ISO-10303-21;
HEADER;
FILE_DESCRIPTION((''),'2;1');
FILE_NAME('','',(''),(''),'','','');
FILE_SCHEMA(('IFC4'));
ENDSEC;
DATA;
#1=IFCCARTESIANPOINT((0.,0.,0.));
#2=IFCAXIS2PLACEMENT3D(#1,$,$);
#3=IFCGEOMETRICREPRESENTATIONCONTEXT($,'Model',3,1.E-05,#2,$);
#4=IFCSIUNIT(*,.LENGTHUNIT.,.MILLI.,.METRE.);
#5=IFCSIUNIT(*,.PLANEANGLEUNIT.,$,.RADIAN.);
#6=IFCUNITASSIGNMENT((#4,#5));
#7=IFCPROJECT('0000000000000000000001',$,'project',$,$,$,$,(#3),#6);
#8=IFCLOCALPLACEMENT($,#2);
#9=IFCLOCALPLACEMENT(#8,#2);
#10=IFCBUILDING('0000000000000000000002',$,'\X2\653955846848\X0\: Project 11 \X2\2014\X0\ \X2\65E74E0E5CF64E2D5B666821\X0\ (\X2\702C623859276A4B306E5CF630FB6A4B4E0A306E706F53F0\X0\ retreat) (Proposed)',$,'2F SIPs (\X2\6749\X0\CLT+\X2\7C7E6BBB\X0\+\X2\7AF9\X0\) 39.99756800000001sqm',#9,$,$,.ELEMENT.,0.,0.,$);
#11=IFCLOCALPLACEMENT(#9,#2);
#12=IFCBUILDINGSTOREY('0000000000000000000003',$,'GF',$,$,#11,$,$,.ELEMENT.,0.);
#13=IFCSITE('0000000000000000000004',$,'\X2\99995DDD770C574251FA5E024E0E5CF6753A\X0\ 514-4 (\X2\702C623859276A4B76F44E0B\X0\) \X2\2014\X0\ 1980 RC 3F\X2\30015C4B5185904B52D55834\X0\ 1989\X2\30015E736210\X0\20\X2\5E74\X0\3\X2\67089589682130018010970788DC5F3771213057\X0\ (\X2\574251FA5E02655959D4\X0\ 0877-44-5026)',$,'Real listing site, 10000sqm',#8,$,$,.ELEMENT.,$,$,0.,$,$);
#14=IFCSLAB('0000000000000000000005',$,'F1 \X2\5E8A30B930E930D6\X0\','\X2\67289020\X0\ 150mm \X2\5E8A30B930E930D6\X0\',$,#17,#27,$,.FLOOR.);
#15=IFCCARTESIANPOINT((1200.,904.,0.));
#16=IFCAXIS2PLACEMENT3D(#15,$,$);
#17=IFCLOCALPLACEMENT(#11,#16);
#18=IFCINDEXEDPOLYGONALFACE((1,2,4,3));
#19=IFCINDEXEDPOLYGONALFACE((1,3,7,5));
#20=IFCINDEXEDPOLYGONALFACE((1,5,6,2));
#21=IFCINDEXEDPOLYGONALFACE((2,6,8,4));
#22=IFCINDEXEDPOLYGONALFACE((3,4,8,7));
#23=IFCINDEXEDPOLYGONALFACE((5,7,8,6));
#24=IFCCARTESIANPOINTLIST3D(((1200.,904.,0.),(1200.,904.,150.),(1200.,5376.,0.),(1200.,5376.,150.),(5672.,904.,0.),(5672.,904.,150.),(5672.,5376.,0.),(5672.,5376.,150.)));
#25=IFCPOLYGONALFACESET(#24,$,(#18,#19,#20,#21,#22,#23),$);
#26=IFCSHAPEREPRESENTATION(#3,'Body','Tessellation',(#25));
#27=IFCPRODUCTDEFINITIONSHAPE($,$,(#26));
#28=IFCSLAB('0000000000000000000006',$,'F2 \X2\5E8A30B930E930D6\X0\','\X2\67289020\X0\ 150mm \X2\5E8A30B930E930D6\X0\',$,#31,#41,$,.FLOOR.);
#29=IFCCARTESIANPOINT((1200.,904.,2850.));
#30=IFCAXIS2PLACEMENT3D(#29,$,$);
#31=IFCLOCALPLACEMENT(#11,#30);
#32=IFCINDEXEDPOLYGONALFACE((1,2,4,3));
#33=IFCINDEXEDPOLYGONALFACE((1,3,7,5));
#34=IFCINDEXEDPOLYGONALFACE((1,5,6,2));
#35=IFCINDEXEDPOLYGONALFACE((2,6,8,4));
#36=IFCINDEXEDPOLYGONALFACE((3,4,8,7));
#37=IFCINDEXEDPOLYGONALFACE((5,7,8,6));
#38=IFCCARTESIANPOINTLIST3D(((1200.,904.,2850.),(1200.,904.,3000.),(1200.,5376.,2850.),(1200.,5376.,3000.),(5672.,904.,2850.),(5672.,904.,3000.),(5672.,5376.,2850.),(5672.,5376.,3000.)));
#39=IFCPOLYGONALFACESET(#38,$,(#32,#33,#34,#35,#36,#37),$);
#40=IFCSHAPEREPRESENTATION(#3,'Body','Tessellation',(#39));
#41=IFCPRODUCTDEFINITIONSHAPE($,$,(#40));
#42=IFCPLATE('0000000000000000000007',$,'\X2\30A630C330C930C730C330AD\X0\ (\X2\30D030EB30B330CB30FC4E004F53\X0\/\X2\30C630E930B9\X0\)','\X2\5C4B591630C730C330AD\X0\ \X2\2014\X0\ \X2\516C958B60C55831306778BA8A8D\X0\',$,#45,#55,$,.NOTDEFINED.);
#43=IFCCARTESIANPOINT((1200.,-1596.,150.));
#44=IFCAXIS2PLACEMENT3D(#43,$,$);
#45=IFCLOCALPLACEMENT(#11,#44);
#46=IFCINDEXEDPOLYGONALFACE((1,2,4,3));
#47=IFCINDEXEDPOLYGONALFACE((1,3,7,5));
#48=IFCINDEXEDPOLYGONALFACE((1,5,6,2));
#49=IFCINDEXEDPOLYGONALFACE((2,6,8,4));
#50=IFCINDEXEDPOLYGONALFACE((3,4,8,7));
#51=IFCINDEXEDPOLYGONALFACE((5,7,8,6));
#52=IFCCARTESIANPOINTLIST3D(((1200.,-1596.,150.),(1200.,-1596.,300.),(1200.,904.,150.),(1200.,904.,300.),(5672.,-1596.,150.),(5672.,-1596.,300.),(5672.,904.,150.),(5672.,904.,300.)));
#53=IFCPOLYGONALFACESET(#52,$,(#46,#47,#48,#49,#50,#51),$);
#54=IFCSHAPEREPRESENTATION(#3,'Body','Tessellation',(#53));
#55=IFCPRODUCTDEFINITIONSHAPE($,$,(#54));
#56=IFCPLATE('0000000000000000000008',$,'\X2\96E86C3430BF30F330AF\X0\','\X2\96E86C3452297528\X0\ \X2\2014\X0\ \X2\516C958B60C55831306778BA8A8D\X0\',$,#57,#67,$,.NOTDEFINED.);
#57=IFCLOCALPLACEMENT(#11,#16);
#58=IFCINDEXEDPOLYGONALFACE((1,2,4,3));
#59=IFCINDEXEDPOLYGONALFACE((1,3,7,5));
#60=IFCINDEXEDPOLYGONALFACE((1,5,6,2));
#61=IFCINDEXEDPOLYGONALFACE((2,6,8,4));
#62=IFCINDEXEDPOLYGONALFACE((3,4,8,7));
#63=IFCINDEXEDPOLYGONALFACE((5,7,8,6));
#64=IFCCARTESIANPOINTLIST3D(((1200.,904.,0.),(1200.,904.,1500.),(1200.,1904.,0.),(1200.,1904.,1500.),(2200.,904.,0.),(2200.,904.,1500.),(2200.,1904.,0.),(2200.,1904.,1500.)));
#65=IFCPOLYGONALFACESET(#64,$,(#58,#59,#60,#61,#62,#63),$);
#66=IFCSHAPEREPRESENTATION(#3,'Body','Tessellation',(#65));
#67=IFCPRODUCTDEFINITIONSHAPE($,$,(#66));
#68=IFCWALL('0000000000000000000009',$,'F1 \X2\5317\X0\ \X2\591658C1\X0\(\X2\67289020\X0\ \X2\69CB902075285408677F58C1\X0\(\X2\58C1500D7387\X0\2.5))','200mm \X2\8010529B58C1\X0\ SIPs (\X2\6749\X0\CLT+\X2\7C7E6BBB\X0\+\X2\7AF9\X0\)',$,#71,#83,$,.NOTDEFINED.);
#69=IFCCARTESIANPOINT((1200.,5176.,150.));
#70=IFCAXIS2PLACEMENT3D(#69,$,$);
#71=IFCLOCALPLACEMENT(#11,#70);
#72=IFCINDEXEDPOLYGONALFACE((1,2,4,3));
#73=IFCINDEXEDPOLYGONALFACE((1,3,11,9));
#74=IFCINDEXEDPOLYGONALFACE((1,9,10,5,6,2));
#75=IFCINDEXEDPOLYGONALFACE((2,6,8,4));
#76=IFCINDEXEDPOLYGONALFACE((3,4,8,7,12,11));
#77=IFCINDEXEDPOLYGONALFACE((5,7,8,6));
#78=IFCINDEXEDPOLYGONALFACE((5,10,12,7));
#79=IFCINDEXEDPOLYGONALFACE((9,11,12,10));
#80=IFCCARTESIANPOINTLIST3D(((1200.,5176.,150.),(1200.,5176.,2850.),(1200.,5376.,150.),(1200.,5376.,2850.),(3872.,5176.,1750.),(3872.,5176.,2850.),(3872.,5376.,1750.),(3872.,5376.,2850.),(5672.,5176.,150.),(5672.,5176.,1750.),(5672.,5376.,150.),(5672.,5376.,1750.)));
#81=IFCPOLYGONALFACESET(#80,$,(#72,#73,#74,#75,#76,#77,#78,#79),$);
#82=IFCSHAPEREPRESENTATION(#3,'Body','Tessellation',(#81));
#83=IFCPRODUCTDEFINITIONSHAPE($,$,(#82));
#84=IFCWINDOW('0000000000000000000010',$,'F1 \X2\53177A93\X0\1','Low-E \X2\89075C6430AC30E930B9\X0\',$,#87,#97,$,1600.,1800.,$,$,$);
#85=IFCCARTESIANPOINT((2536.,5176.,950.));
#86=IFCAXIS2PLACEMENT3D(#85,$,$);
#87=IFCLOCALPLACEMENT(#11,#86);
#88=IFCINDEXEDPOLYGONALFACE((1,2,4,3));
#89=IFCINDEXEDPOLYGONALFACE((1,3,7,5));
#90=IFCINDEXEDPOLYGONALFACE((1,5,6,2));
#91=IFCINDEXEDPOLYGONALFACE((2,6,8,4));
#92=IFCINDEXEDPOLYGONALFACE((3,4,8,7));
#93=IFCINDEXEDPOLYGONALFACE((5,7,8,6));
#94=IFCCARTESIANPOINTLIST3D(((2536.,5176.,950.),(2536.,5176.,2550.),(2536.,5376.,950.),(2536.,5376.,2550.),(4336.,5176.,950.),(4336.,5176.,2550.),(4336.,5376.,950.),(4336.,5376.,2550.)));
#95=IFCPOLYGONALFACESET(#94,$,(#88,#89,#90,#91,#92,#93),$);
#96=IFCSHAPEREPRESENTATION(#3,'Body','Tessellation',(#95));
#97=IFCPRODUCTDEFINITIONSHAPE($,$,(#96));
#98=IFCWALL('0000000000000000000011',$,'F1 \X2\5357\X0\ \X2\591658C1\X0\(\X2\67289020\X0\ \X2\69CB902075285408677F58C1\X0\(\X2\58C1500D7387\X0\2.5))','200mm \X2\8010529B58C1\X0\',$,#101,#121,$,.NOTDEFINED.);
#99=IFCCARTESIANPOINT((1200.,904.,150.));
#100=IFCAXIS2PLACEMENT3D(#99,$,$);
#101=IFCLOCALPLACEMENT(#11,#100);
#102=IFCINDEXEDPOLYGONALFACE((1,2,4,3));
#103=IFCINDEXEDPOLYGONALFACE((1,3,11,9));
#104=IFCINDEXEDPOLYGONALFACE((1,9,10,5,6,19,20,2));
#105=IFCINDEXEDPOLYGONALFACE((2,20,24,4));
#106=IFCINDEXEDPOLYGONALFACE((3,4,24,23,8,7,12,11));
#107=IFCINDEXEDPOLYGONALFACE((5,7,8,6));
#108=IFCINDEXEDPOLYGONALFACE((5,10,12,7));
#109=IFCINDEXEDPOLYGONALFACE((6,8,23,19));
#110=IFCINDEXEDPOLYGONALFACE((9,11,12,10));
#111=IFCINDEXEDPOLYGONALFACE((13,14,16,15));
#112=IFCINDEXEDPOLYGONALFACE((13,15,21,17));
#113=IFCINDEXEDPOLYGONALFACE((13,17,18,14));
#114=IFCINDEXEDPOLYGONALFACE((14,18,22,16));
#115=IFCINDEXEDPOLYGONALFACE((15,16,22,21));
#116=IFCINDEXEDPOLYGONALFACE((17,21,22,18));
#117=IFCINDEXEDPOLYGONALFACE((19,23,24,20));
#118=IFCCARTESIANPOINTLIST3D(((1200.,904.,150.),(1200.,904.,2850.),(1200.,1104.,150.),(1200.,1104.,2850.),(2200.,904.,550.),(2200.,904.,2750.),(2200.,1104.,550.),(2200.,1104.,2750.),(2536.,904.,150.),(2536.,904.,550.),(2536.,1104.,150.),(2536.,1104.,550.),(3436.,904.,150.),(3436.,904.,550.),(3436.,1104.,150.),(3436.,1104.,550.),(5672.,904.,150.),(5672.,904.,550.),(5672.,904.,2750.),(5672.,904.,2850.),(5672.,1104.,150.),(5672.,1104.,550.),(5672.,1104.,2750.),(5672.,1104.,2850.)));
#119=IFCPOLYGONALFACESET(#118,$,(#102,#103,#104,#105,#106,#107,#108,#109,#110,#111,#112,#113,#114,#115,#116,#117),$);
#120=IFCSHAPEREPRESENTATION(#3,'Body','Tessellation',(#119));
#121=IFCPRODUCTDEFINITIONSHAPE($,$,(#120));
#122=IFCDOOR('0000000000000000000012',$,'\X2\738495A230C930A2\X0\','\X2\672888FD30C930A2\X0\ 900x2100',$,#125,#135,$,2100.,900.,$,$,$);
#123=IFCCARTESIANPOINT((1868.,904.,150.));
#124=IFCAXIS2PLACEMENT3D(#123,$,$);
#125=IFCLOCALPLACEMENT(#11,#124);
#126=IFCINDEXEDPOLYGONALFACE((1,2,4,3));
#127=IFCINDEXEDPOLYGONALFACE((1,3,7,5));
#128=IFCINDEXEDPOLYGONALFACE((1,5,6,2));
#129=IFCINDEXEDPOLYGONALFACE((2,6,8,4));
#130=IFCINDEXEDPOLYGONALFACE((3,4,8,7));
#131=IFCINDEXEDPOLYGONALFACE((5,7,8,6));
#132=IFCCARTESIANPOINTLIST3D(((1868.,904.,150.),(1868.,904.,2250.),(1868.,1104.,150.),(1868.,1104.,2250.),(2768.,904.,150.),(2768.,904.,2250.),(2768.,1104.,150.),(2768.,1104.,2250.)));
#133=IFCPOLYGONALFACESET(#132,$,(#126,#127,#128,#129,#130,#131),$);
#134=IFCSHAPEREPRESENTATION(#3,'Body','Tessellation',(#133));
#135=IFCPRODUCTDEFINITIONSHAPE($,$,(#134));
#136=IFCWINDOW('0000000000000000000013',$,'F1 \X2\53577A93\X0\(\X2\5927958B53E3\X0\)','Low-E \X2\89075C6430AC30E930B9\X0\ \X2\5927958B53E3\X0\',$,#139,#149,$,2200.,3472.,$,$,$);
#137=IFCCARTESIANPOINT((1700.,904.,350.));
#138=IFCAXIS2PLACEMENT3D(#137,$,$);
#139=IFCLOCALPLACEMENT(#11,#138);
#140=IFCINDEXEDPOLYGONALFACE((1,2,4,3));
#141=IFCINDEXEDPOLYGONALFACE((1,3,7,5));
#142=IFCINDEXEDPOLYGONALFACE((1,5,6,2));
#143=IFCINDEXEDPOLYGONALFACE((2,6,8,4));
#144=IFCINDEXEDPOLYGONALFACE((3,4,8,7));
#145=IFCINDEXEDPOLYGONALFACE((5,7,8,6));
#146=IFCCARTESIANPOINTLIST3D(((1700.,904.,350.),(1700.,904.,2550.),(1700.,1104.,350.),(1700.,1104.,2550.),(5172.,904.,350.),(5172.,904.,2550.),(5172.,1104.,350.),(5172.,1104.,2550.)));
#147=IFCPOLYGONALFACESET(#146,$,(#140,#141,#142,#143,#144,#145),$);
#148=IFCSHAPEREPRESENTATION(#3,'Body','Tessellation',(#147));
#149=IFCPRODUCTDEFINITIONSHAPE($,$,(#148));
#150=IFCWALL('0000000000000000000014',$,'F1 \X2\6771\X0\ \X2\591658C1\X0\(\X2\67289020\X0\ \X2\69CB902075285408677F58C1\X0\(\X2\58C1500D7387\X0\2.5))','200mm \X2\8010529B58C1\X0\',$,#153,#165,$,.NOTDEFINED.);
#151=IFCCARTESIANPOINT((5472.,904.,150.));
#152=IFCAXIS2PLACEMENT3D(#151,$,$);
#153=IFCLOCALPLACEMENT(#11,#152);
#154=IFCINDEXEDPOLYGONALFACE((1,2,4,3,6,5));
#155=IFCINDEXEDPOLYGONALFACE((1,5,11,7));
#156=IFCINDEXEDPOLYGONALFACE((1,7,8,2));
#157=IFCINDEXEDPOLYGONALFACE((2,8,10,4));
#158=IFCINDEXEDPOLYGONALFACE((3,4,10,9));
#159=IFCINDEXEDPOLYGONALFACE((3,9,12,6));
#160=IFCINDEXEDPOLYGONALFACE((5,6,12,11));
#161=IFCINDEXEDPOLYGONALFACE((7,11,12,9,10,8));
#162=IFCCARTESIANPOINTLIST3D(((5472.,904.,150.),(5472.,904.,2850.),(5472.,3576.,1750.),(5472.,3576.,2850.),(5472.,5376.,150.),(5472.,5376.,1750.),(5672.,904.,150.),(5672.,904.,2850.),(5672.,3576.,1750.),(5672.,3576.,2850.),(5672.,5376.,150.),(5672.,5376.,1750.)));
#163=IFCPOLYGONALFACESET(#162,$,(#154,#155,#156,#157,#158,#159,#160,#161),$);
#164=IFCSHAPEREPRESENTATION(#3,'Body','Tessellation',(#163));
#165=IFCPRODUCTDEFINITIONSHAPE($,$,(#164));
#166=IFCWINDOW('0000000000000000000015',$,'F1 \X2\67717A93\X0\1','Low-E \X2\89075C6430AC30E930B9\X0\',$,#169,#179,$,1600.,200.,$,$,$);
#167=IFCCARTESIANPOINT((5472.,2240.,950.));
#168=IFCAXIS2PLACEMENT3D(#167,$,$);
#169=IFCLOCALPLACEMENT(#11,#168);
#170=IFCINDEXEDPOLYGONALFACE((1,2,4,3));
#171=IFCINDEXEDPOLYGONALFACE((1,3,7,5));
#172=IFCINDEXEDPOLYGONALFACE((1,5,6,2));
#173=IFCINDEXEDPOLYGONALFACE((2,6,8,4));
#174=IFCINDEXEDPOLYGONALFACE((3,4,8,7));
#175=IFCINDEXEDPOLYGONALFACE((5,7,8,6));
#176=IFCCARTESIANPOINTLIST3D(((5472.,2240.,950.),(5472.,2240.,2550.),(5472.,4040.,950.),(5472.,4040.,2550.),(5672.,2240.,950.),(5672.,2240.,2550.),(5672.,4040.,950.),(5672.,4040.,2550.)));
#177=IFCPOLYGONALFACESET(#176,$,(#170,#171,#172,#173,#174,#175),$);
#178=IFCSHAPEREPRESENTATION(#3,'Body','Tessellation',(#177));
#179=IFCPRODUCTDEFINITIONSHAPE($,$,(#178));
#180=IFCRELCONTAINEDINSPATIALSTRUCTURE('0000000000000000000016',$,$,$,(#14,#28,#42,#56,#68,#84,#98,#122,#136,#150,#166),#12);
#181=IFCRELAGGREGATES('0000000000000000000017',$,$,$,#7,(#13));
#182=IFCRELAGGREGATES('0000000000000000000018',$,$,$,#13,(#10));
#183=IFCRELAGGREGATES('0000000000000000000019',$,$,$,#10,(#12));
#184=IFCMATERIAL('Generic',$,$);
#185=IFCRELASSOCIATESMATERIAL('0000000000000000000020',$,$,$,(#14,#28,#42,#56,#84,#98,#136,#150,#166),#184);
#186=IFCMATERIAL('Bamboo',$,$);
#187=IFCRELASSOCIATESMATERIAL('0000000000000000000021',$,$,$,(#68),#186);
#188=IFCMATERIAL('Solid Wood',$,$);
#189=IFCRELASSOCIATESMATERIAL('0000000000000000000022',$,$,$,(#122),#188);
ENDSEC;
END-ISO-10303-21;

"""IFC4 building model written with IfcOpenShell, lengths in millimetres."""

from ifc_helpers import new_model, si_unit, frame, frame_2d, origin, place, context, project, spatial, rectangle, extrude, material, element, fill, save


model = new_model("IFC4")

# Units and contexts
model_context = context("Model", 3, precision=1e-05, world=origin())
ifc_project = project(units=[si_unit("LENGTHUNIT", "METRE", prefix="MILLI"), si_unit("PLANEANGLEUNIT", "RADIAN")], contexts=[model_context])

# Site, building, storey
site_placement = place(None, origin())
site = spatial("IfcSite", under=ifc_project, at=site_placement, Name="香川県坂出市与島町 514-4 (瀬戸大橋直下) — 1980 RC 3F、屋内運動場 1989、平成20年3月閉校、耐震補強無し (坂出市教委 0877-44-5026)", ObjectType="Real listing site, 10000sqm", CompositionType="ELEMENT", RefElevation=0.0)
building_placement = place(site_placement, origin())
building = spatial("IfcBuilding", under=site, at=building_placement, Name="改善案: Project 11 — 旧与島中学校 (瀬戸大橋の島・橋上の灯台 retreat) (Proposed)", ObjectType="2F SIPs (杉CLT+籾殻+竹) 39.99756800000001sqm", CompositionType="ELEMENT", ElevationOfRefHeight=0.0, ElevationOfTerrain=0.0)
storey_placement = place(building_placement, origin())
storey = spatial("IfcBuildingStorey", under=building, at=storey_placement, Name="GF", CompositionType="ELEMENT", Elevation=0.0)

# Slabs
ifc_material_1 = material(Name="Generic")
slab_1_placement = place(storey_placement, frame((1200.0, 904.0, 0.0)))
element("IfcSlab", 1, at=slab_1_placement, inside=storey, material=ifc_material_1, Name="F1 床スラブ", Description="木造 150mm 床スラブ", PredefinedType="FLOOR", context=model_context, shape_type="SweptSolid", body=[
    extrude(rectangle(XDim=4472.0, YDim=4472.0, at=frame_2d((2236.0, 2236.0))), frame((1200.0, 904.0, 0.0)), (0.0, 0.0, 1.0), 150.0),
])
slab_2_placement = place(storey_placement, frame((1200.0, 904.0, 2850.0)))
element("IfcSlab", 2, at=slab_2_placement, inside=storey, material=ifc_material_1, Name="F2 床スラブ", Description="木造 150mm 床スラブ", PredefinedType="FLOOR", context=model_context, shape_type="SweptSolid", body=[
    extrude(rectangle(XDim=4472.0, YDim=4472.0, at=frame_2d((2236.0, 2236.0))), frame((1200.0, 904.0, 2850.0)), (0.0, 0.0, 1.0), 150.0),
])

# Plates
plate_1_placement = place(storey_placement, frame((1200.0, -1596.0, 150.0)))
element("IfcPlate", 3, at=plate_1_placement, inside=storey, material=ifc_material_1, Name="ウッドデッキ (バルコニー一体/テラス)", Description="屋外デッキ — 公開情報で確認", PredefinedType="NOTDEFINED", context=model_context, shape_type="SweptSolid", body=[
    extrude(rectangle(XDim=4472.0, YDim=2500.0, at=frame_2d((2236.0, 1250.0))), frame((1200.0, -1596.0, 150.0)), (0.0, 0.0, 1.0), 150.0),
])
plate_2_placement = place(storey_placement, frame((1200.0, 904.0, 0.0)))
element("IfcPlate", 4, at=plate_2_placement, inside=storey, material=ifc_material_1, Name="雨水タンク", Description="雨水利用 — 公開情報で確認", PredefinedType="NOTDEFINED", context=model_context, shape_type="SweptSolid", body=[
    extrude(rectangle(XDim=1000.0, YDim=1000.0, at=frame_2d((500.0, 500.0))), frame((1200.0, 904.0, 0.0)), (0.0, 0.0, 1.0), 1500.0),
])

# Wall, opening, window
ifc_material_2 = material(Name="Bamboo")
wall_1_placement = place(storey_placement, frame((1200.0, 5176.0, 150.0)))
wall_1 = element("IfcWall", 5, at=wall_1_placement, inside=storey, material=ifc_material_2, Name="F1 北 外壁(木造 構造用合板壁(壁倍率2.5))", Description="200mm 耐力壁 SIPs (杉CLT+籾殻+竹)", PredefinedType="NOTDEFINED", context=model_context, shape_type="SweptSolid", body=[
    extrude(rectangle(XDim=4472.0, YDim=200.0, at=frame_2d((2236.0, 100.0))), frame((1200.0, 5176.0, 150.0)), (0.0, 0.0, 1.0), 2700.0),
])
opening_1_placement = place(storey_placement, frame((2536.0, 5176.0, 950.0)))
opening_1 = element("IfcOpeningElement", 6, at=opening_1_placement, cuts=wall_1, PredefinedType="NOTDEFINED", context=model_context, shape_type="SweptSolid", body=[
    extrude(rectangle(XDim=1800.0, YDim=200.0, at=frame_2d((900.0, 100.0))), frame((2536.0, 5176.0, 950.0)), (0.0, 0.0, 1.0), 1600.0),
])
window_1_placement = place(storey_placement, frame((2536.0, 5176.0, 950.0)))
window_1 = element("IfcWindow", 7, at=window_1_placement, inside=storey, material=ifc_material_1, Name="F1 北窓1", Description="Low-E 複層ガラス", OverallHeight=1600.0, OverallWidth=1800.0, context=model_context, shape_type="SweptSolid", body=[
    extrude(rectangle(XDim=1800.0, YDim=200.0, at=frame_2d((900.0, 100.0))), frame((2536.0, 5176.0, 950.0)), (0.0, 0.0, 1.0), 1600.0),
])
fill(opening_1, window_1)

# Wall, openings, door, window
wall_2_placement = place(storey_placement, frame((1200.0, 904.0, 150.0)))
wall_2 = element("IfcWall", 8, at=wall_2_placement, inside=storey, material=ifc_material_1, Name="F1 南 外壁(木造 構造用合板壁(壁倍率2.5))", Description="200mm 耐力壁", PredefinedType="NOTDEFINED", context=model_context, shape_type="SweptSolid", body=[
    extrude(rectangle(XDim=4472.0, YDim=200.0, at=frame_2d((2236.0, 100.0))), frame((1200.0, 904.0, 150.0)), (0.0, 0.0, 1.0), 2700.0),
])
opening_2_placement = place(storey_placement, frame((1868.0, 904.0, 150.0)))
opening_2 = element("IfcOpeningElement", 9, at=opening_2_placement, cuts=wall_2, PredefinedType="NOTDEFINED", context=model_context, shape_type="SweptSolid", body=[
    extrude(rectangle(XDim=900.0, YDim=200.0, at=frame_2d((450.0, 100.0))), frame((1868.0, 904.0, 150.0)), (0.0, 0.0, 1.0), 2100.0),
])
opening_3_placement = place(storey_placement, frame((1700.0, 904.0, 350.0)))
opening_3 = element("IfcOpeningElement", 10, at=opening_3_placement, cuts=wall_2, PredefinedType="NOTDEFINED", context=model_context, shape_type="SweptSolid", body=[
    extrude(rectangle(XDim=3472.0, YDim=200.0, at=frame_2d((1736.0, 100.0))), frame((1700.0, 904.0, 350.0)), (0.0, 0.0, 1.0), 2200.0),
])
ifc_material_3 = material(Name="Solid Wood")
door_placement = place(storey_placement, frame((1868.0, 904.0, 150.0)))
door = element("IfcDoor", 11, at=door_placement, inside=storey, material=ifc_material_3, Name="玄関ドア", Description="木製ドア 900x2100", OverallHeight=2100.0, OverallWidth=900.0, context=model_context, shape_type="SweptSolid", body=[
    extrude(rectangle(XDim=900.0, YDim=200.0, at=frame_2d((450.0, 100.0))), frame((1868.0, 904.0, 150.0)), (0.0, 0.0, 1.0), 2100.0),
])
fill(opening_2, door)
window_2_placement = place(storey_placement, frame((1700.0, 904.0, 350.0)))
window_2 = element("IfcWindow", 12, at=window_2_placement, inside=storey, material=ifc_material_1, Name="F1 南窓(大開口)", Description="Low-E 複層ガラス 大開口", OverallHeight=2200.0, OverallWidth=3472.0, context=model_context, shape_type="SweptSolid", body=[
    extrude(rectangle(XDim=3472.0, YDim=200.0, at=frame_2d((1736.0, 100.0))), frame((1700.0, 904.0, 350.0)), (0.0, 0.0, 1.0), 2200.0),
])
fill(opening_3, window_2)

# Wall, opening, window
wall_3_placement = place(storey_placement, frame((5472.0, 904.0, 150.0)))
wall_3 = element("IfcWall", 13, at=wall_3_placement, inside=storey, material=ifc_material_1, Name="F1 東 外壁(木造 構造用合板壁(壁倍率2.5))", Description="200mm 耐力壁", PredefinedType="NOTDEFINED", context=model_context, shape_type="SweptSolid", body=[
    extrude(rectangle(XDim=200.0, YDim=4472.0, at=frame_2d((100.0, 2236.0))), frame((5472.0, 904.0, 150.0)), (0.0, 0.0, 1.0), 2700.0),
])
opening_4_placement = place(storey_placement, frame((5472.0, 2240.0, 950.0)))
opening_4 = element("IfcOpeningElement", 14, at=opening_4_placement, cuts=wall_3, PredefinedType="NOTDEFINED", context=model_context, shape_type="SweptSolid", body=[
    extrude(rectangle(XDim=200.0, YDim=1800.0, at=frame_2d((100.0, 900.0))), frame((5472.0, 2240.0, 950.0)), (0.0, 0.0, 1.0), 1600.0),
])
window_3_placement = place(storey_placement, frame((5472.0, 2240.0, 950.0)))
window_3 = element("IfcWindow", 15, at=window_3_placement, inside=storey, material=ifc_material_1, Name="F1 東窓1", Description="Low-E 複層ガラス", OverallHeight=1600.0, OverallWidth=200.0, context=model_context, shape_type="SweptSolid", body=[
    extrude(rectangle(XDim=200.0, YDim=1800.0, at=frame_2d((100.0, 900.0))), frame((5472.0, 2240.0, 950.0)), (0.0, 0.0, 1.0), 1600.0),
])
fill(opening_4, window_3)

save(model, "model.ifc")
